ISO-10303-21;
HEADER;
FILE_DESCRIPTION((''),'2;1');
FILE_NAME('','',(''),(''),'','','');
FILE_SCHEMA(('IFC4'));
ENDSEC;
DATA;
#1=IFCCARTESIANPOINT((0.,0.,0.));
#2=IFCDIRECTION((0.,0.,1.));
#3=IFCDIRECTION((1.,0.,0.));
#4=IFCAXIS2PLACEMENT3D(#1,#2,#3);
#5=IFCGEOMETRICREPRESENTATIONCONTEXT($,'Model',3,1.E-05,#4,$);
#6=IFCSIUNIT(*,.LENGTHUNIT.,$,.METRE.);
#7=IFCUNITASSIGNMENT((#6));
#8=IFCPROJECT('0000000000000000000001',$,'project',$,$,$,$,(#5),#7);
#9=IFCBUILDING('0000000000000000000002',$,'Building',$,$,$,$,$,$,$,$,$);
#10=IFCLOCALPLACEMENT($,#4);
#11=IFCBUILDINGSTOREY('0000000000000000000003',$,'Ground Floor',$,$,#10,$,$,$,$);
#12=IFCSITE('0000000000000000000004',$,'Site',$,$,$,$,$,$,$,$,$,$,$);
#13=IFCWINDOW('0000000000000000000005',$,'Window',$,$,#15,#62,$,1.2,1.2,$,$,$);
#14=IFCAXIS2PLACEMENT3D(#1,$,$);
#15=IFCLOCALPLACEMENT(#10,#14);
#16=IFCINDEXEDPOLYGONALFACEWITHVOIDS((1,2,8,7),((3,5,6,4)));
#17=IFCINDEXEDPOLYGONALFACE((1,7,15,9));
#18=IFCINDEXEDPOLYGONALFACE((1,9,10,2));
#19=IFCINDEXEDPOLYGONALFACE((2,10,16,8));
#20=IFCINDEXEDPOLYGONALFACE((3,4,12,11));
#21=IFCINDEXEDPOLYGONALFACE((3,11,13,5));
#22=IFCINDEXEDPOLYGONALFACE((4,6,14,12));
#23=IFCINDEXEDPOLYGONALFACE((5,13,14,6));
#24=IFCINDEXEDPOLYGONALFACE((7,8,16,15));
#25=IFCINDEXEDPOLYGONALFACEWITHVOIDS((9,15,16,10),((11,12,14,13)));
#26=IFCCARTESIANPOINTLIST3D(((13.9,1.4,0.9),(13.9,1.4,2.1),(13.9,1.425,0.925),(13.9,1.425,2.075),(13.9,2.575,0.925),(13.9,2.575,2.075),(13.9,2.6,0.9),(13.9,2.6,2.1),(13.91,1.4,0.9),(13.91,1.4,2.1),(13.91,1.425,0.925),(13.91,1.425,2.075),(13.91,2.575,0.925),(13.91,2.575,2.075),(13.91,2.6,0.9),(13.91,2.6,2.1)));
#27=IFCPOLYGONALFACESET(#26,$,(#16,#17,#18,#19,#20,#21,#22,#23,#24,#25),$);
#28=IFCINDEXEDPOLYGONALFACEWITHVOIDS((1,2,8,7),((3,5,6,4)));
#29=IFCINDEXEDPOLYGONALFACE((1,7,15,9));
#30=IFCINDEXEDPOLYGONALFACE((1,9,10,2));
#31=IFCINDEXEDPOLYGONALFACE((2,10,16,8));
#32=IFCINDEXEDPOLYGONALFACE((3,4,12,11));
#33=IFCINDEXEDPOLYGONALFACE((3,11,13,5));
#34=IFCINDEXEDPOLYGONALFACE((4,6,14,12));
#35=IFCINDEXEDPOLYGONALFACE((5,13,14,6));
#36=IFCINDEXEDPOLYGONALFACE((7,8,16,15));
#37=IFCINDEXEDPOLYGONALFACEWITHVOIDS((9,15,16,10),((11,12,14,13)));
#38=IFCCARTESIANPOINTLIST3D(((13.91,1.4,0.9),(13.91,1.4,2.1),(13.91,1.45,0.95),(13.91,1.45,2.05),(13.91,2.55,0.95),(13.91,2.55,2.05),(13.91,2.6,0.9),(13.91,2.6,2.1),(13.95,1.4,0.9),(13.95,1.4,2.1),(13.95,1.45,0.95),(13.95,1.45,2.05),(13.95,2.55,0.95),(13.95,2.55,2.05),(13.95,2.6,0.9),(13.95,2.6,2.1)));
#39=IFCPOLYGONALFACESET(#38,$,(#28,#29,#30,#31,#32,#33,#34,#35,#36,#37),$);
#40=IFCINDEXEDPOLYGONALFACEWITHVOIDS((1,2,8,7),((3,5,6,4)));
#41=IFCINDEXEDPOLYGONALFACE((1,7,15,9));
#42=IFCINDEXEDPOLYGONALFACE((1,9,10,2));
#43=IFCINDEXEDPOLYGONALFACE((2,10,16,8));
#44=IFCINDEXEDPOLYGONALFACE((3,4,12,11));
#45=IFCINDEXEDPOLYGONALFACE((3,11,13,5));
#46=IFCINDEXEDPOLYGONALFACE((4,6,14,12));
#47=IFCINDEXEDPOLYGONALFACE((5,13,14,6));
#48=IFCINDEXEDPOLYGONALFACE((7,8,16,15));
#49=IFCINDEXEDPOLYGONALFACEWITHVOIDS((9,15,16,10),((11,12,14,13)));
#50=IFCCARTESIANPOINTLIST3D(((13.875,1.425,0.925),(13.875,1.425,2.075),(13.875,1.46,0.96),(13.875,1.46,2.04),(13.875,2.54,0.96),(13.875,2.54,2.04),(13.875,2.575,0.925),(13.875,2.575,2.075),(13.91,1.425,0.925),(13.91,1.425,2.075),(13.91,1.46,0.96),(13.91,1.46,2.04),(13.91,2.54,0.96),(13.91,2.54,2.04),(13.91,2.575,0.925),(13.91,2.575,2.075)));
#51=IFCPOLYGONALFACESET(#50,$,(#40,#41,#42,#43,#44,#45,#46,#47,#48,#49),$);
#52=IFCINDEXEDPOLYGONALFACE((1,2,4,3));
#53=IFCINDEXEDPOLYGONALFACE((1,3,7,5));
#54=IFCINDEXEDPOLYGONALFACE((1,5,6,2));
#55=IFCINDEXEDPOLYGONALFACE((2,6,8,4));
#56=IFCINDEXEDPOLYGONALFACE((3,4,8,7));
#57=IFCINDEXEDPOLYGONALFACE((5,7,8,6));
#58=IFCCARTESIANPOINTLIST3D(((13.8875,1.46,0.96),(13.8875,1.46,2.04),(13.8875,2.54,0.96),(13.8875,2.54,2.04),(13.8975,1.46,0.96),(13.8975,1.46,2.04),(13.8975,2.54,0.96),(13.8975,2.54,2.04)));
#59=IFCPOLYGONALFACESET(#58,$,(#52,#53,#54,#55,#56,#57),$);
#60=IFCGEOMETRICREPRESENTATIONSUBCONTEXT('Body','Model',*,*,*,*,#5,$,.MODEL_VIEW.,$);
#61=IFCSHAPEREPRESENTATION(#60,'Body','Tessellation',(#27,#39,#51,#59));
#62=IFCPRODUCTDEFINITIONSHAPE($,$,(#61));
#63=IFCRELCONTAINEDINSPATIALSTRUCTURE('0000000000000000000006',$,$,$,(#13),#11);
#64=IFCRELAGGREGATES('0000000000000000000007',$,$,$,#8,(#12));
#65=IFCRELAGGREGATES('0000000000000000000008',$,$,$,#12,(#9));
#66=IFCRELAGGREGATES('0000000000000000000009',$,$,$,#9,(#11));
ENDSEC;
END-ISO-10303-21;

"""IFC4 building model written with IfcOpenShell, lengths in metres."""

from ifc_helpers import new_model, si_unit, frame, origin_with_axes, place, context, subcontext, project, spatial, line, indexed_curve, outline, extrude, element, save


model = new_model("IFC4")

# Units and contexts
model_context = context("Model", 3, precision=1e-05, world=origin_with_axes())
body_context = subcontext(model_context, "Body", "Model", "MODEL_VIEW")
ifc_project = project(units=[si_unit("LENGTHUNIT", "METRE")], contexts=[model_context])

# Site, building, storey
site = spatial("IfcSite", under=ifc_project, Name="Site")
building = spatial("IfcBuilding", under=site, Name="Building")
storey_placement = place(None, origin_with_axes())
storey = spatial("IfcBuildingStorey", under=building, at=storey_placement, Name="Ground Floor")

# Window
window_1_placement = place(storey_placement, frame((14.0, 1.4, 0.9), z_axis=(0.0, 0.0, 1.0), x_axis=(0.0, 1.0, 0.0)))
element("IfcWindow", 1, at=window_1_placement, inside=storey, Name="Window", OverallHeight=1.2, OverallWidth=1.2, context=body_context, shape_type="SweptSolid", body=[
    extrude(outline(indexed_curve([(0.0, 0.0), (1.2, 0.0), (1.2, 1.2), (0.0, 1.2)], segments=[line(1, 2, 3, 4, 1)]), holes=[indexed_curve([(0.025, 0.025), (1.175, 0.025), (1.175, 1.175), (0.025, 1.175)], segments=[line(1, 2, 3, 4, 1)])]), frame((0.0, 0.09, 0.0), z_axis=(0.0, -1.0, 0.0), x_axis=(1.0, 0.0, 0.0)), (0.0, 0.0, -1.0), 0.01),
    extrude(outline(indexed_curve([(0.0, 0.0), (1.2, 0.0), (1.2, 1.2), (0.0, 1.2)], segments=[line(1, 2, 3, 4, 1)]), holes=[indexed_curve([(0.05, 0.05), (1.15, 0.05), (1.15, 1.15), (0.05, 1.15)], segments=[line(1, 2, 3, 4, 1)])]), frame((0.0, 0.05, 0.0), z_axis=(0.0, -1.0, 0.0), x_axis=(1.0, 0.0, 0.0)), (0.0, 0.0, -1.0), 0.04),
    extrude(outline(indexed_curve([(0.0, 0.0), (1.15, 0.0), (1.15, 1.15), (0.0, 1.15)], segments=[line(1, 2, 3, 4, 1)]), holes=[indexed_curve([(0.035, 0.035), (1.115, 0.035), (1.115, 1.115), (0.035, 1.115)], segments=[line(1, 2, 3, 4, 1)])]), frame((0.025, 0.09, 0.025), z_axis=(0.0, -1.0, 0.0), x_axis=(1.0, 0.0, 0.0)), (0.0, 0.0, -1.0), 0.035),
    extrude(outline(indexed_curve([(0.035, 0.035), (1.115, 0.035), (1.115, 1.115), (0.035, 1.115)], segments=[line(1, 2, 3, 4, 1)])), frame((0.025, 0.1025, 0.025), z_axis=(0.0, -1.0, 0.0), x_axis=(1.0, 0.0, 0.0)), (0.0, 0.0, -1.0), 0.01),
])

save(model, "model.ifc")
